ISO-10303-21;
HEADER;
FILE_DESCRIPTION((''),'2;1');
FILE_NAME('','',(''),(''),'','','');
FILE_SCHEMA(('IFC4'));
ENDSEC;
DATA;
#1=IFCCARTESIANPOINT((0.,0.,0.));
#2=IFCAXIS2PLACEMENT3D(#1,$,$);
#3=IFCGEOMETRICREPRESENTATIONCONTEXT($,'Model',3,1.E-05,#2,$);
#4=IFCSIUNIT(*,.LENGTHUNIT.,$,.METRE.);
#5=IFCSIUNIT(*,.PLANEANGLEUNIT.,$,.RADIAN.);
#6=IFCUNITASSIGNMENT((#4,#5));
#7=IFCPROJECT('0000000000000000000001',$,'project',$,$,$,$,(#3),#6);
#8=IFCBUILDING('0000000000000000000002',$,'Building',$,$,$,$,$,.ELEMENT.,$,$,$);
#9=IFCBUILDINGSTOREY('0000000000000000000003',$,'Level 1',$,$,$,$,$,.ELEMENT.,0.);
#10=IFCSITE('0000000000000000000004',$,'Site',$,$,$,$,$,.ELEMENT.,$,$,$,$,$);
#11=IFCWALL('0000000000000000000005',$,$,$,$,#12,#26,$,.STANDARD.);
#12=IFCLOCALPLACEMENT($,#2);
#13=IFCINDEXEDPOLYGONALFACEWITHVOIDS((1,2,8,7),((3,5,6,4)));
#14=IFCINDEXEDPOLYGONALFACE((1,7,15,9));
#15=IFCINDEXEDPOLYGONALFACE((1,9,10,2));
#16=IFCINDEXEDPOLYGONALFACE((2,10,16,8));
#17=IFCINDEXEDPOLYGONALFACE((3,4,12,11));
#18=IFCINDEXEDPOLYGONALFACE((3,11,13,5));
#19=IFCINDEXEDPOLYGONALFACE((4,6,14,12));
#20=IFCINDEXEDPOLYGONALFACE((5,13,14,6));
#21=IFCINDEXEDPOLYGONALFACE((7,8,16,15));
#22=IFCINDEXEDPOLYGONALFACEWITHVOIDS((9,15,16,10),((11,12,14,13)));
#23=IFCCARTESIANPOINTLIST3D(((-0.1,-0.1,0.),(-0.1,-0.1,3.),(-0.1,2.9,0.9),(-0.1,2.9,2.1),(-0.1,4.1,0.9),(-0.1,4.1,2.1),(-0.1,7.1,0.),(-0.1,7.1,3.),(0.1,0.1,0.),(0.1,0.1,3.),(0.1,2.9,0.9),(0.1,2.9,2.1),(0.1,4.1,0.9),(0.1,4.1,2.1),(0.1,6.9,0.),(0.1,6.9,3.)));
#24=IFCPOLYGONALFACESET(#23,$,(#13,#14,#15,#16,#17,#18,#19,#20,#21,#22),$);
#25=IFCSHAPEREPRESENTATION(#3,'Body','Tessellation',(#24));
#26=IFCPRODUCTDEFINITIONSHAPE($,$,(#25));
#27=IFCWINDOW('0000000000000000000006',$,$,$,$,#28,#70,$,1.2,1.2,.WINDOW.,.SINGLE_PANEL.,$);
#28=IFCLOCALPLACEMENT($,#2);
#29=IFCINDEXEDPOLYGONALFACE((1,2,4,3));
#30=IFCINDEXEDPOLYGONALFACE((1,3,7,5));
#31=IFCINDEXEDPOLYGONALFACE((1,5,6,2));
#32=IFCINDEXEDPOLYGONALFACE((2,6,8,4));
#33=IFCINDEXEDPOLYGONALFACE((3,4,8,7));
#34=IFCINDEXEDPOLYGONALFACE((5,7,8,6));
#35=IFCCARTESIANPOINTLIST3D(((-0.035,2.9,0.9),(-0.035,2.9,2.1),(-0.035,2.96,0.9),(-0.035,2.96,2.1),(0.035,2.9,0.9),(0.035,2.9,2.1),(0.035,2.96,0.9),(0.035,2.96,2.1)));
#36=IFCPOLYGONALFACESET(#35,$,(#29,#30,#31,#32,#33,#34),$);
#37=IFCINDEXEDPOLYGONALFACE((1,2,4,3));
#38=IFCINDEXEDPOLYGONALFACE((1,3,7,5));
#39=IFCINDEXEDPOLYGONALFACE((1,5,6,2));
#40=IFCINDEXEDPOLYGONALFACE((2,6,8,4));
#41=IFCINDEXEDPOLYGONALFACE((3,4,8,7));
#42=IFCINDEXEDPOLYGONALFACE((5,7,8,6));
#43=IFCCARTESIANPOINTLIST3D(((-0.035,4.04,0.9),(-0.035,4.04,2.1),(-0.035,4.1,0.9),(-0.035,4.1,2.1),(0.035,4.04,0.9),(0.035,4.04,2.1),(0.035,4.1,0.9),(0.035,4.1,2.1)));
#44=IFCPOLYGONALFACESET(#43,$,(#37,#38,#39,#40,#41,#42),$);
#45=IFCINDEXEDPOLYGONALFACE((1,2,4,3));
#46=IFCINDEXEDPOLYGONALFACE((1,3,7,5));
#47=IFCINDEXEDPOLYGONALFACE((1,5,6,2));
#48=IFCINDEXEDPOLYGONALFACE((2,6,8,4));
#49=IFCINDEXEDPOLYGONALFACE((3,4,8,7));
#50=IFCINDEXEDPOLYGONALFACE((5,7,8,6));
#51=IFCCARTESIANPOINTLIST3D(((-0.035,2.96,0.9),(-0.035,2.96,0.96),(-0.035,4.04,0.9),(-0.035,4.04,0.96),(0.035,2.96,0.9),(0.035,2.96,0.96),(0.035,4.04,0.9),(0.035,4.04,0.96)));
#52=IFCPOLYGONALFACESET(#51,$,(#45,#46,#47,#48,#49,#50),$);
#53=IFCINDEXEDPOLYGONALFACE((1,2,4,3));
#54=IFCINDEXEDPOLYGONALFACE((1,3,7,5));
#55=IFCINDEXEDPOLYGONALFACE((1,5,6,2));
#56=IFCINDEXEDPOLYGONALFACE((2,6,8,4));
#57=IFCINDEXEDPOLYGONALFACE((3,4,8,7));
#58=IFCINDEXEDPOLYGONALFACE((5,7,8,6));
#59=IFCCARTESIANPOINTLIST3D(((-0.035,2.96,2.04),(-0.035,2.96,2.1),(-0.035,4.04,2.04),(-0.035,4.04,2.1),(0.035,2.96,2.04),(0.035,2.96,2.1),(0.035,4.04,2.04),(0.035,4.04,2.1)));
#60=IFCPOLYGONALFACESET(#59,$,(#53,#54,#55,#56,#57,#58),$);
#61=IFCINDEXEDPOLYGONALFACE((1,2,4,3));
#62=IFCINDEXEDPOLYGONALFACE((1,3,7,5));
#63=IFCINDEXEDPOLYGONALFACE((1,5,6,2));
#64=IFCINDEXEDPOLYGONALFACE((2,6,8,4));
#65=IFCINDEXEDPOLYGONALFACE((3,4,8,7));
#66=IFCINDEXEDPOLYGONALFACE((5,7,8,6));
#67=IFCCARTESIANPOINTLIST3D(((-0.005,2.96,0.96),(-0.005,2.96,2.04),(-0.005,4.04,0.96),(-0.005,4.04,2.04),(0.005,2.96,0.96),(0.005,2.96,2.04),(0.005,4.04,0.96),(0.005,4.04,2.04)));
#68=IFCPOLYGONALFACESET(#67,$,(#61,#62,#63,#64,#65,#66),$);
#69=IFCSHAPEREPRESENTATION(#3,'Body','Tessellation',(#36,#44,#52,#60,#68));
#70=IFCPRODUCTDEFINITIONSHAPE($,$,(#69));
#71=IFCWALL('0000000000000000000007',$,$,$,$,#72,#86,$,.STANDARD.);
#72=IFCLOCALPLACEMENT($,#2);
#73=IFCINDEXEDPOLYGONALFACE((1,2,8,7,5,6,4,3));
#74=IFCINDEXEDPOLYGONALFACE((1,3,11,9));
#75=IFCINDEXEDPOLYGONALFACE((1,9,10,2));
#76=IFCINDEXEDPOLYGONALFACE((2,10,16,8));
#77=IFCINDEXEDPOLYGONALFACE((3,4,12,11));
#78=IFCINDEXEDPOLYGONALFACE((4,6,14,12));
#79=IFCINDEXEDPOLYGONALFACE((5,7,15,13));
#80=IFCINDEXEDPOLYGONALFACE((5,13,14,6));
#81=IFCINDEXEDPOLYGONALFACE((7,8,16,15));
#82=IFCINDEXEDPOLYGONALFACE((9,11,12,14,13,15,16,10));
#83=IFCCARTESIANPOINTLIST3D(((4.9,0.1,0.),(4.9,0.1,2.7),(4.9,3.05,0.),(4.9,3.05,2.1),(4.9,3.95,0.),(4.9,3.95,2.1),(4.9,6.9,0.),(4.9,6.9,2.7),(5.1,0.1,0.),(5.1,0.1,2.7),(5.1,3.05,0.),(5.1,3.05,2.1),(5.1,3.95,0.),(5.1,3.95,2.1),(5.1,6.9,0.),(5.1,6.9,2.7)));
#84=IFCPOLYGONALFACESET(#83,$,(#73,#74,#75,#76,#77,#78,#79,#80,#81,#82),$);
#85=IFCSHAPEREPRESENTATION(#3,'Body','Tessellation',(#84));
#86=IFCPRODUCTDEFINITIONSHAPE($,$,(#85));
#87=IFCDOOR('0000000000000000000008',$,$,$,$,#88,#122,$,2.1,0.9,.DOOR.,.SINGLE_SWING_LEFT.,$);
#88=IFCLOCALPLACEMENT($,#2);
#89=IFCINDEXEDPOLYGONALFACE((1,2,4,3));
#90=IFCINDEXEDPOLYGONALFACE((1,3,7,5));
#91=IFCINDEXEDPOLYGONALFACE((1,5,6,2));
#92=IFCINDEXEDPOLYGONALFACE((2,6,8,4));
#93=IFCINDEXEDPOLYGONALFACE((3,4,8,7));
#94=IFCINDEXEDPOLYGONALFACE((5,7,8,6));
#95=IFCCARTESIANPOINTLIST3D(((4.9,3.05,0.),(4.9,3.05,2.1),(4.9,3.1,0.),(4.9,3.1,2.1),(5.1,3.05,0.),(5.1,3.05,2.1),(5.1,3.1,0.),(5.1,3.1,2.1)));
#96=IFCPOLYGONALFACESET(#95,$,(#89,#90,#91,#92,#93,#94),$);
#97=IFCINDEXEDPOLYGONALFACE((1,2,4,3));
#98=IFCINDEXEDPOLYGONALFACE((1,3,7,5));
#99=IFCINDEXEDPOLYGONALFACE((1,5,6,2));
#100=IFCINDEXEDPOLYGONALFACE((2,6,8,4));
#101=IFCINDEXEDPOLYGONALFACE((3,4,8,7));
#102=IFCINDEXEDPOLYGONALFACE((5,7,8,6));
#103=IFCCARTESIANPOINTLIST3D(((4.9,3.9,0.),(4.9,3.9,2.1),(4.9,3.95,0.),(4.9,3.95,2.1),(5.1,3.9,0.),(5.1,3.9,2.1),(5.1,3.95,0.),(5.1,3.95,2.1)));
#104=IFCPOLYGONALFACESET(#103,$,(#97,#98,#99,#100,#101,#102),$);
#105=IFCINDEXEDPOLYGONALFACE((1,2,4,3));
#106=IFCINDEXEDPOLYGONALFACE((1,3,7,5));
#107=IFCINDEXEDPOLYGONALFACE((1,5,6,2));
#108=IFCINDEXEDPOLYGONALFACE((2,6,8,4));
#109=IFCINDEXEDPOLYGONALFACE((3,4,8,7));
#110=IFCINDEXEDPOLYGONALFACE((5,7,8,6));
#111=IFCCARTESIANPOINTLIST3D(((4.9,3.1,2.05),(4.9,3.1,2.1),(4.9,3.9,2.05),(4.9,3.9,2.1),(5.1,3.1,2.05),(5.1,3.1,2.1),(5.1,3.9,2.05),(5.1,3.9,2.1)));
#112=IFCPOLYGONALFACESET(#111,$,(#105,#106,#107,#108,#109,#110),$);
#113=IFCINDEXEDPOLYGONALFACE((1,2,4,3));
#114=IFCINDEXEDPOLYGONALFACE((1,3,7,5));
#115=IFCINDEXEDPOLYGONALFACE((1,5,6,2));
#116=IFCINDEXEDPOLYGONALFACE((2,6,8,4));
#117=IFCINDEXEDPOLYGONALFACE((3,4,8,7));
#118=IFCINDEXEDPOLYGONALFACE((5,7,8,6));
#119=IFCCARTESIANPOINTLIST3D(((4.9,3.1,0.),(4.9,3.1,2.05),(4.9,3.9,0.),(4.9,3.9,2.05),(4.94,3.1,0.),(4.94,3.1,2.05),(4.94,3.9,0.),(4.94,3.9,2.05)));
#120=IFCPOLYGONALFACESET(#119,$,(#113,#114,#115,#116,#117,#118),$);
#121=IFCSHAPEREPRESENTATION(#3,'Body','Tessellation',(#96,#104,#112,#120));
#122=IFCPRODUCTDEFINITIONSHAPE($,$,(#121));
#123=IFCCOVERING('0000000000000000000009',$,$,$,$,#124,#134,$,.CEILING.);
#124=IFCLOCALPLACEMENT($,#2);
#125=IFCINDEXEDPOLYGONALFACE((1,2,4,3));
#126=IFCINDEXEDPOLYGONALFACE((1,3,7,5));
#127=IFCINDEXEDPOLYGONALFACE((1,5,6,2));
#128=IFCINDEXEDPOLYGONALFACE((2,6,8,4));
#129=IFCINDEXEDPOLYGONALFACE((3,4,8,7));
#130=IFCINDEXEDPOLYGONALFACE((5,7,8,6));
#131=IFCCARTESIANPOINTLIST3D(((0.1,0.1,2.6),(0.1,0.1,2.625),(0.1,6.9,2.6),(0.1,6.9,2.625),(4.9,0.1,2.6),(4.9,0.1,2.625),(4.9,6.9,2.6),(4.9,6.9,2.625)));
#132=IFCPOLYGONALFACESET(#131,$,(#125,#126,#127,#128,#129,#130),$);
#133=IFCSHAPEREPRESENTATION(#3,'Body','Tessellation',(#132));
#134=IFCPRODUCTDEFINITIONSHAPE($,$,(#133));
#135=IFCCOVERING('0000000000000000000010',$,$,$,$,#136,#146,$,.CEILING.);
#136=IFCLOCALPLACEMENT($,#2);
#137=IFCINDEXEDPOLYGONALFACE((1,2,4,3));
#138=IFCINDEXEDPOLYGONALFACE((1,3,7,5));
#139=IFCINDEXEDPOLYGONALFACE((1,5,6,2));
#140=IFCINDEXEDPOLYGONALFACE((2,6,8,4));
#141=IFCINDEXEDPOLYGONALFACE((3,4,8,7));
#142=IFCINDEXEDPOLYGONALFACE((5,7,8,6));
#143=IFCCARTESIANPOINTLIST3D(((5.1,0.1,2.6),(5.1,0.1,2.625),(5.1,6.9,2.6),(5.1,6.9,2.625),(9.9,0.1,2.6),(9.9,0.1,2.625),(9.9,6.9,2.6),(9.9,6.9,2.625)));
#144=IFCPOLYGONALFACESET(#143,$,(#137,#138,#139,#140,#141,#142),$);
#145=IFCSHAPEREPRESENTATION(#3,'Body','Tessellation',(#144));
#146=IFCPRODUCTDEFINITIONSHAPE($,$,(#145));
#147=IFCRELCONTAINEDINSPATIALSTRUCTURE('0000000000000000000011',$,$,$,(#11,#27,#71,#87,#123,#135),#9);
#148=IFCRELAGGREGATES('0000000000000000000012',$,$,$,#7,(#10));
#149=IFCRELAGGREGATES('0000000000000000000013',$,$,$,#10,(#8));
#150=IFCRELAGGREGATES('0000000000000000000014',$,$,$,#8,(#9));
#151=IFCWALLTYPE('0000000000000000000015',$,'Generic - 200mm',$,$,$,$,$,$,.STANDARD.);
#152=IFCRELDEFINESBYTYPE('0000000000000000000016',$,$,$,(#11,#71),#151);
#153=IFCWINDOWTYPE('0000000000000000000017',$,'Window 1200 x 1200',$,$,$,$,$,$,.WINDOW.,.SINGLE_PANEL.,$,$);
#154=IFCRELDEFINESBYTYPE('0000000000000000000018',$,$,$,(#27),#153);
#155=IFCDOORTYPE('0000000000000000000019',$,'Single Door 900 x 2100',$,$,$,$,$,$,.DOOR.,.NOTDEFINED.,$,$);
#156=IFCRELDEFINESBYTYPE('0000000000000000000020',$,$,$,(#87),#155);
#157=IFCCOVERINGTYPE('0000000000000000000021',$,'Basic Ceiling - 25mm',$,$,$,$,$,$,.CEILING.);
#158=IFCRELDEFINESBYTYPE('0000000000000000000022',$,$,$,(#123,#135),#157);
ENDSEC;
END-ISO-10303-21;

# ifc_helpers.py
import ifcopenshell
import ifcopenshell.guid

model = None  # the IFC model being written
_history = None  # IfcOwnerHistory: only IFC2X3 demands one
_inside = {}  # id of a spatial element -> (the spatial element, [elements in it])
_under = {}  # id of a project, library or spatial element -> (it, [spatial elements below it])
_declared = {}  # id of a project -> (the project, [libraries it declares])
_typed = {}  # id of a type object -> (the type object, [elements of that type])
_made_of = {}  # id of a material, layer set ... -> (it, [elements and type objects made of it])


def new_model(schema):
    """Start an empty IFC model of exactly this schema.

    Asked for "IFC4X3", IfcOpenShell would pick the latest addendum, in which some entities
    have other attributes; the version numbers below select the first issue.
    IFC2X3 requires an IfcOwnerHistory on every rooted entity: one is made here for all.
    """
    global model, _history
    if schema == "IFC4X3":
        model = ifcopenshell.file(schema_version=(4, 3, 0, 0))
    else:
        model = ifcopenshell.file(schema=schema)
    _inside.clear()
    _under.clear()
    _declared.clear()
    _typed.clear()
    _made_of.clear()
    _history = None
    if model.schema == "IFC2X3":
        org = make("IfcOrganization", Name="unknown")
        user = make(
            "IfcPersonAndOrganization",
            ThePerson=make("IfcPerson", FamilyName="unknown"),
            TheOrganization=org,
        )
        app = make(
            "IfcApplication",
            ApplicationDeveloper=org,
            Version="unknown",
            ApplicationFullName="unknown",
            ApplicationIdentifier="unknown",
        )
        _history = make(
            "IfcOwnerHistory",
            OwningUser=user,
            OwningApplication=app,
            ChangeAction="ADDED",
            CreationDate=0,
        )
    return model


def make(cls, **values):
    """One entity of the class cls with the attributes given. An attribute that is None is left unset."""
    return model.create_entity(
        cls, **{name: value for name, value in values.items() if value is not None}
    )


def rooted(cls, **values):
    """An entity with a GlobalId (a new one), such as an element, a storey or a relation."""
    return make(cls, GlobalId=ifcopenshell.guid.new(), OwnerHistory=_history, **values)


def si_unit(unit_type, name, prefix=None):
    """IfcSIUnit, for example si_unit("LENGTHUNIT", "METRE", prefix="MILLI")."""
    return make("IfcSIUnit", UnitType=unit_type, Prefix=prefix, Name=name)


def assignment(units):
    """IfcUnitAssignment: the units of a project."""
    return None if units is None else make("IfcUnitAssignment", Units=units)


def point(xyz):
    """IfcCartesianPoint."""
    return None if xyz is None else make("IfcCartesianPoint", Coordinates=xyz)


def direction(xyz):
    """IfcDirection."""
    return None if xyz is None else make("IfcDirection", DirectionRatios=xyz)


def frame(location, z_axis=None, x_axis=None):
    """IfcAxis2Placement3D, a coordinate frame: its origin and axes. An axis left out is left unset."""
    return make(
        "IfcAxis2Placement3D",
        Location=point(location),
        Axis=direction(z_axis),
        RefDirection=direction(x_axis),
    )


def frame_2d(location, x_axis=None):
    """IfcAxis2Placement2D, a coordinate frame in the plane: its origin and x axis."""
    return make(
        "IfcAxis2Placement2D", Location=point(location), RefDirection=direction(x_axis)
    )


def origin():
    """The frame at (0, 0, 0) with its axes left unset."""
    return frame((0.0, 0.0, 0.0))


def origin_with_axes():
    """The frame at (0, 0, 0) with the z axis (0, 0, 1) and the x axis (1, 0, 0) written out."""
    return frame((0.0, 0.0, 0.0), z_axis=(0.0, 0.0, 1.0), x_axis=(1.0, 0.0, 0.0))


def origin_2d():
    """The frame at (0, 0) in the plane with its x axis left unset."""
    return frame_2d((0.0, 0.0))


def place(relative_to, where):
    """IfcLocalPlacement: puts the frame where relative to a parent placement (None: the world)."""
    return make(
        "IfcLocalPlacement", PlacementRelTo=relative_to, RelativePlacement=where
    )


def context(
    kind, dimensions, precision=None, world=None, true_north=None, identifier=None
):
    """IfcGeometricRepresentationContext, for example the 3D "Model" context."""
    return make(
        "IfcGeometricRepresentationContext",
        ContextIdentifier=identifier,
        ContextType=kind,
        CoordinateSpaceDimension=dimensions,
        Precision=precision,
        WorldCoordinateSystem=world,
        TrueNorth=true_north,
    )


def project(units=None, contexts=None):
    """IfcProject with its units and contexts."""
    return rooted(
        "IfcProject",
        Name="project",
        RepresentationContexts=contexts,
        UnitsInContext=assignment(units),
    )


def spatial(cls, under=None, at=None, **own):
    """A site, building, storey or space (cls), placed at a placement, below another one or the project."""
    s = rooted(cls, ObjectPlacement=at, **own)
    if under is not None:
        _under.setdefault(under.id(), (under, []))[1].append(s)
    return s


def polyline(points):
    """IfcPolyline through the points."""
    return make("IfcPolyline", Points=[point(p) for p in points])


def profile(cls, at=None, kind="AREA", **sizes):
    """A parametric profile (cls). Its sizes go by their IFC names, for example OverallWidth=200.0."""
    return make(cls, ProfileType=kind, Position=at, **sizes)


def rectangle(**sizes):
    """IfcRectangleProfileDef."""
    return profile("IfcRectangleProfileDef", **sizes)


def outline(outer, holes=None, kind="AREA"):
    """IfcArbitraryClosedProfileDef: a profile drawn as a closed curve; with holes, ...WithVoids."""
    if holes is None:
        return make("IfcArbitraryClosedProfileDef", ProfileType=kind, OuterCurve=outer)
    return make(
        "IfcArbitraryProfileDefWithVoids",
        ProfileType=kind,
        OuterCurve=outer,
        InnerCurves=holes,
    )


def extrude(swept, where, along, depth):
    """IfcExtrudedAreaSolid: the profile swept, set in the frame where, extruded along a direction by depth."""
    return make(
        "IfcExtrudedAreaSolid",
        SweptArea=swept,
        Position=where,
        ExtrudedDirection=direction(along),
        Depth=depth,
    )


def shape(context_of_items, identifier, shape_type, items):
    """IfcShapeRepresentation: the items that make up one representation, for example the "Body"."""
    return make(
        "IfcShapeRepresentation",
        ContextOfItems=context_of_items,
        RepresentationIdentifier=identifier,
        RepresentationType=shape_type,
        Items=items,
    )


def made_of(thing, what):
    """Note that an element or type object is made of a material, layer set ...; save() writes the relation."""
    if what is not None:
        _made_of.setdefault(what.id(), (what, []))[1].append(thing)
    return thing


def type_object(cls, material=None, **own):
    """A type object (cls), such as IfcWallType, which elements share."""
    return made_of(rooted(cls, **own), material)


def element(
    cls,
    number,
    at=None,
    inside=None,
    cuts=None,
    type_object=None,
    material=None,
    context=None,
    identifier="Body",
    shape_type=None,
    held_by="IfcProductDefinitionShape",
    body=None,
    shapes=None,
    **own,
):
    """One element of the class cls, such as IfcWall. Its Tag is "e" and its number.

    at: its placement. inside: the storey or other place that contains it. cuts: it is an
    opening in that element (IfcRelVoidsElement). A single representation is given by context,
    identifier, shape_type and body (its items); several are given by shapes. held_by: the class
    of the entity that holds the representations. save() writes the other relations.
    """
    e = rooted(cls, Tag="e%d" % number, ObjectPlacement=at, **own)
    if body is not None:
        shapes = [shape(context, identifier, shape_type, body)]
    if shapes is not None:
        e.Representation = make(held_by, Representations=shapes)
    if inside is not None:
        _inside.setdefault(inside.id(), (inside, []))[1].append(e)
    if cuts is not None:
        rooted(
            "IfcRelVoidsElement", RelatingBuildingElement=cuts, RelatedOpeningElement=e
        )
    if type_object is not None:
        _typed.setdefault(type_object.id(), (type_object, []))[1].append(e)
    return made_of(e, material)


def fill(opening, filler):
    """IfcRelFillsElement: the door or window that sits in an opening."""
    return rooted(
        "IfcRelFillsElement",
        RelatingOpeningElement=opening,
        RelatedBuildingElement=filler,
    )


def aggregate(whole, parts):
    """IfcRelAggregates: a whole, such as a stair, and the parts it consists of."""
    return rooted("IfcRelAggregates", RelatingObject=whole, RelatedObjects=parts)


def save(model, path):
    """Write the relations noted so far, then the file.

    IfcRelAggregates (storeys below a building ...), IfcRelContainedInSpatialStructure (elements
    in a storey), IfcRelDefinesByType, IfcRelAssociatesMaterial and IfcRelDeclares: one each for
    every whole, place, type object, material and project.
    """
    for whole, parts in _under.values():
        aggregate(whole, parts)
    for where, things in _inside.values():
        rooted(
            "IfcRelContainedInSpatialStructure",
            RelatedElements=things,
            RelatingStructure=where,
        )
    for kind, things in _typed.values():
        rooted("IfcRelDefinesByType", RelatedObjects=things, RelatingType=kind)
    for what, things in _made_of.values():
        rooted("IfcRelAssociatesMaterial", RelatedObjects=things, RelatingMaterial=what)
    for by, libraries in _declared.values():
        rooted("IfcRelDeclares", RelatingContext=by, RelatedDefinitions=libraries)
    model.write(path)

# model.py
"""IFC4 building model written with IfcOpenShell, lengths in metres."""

from ifc_helpers import new_model, si_unit, frame, frame_2d, origin, origin_with_axes, origin_2d, place, context, project, spatial, polyline, rectangle, outline, extrude, type_object, element, fill, save


model = new_model("IFC4")

# Units and contexts
model_context = context("Model", 3, precision=1e-05, world=origin())
ifc_project = project(units=[si_unit("LENGTHUNIT", "METRE"), si_unit("PLANEANGLEUNIT", "RADIAN")], contexts=[model_context])

# Site, building, storey
site = spatial("IfcSite", under=ifc_project, Name="Site", CompositionType="ELEMENT")
building = spatial("IfcBuilding", under=site, Name="Building", CompositionType="ELEMENT")
storey = spatial("IfcBuildingStorey", under=building, Name="Level 1", CompositionType="ELEMENT", Elevation=0.0)

# Shared definitions
wall_type = type_object("IfcWallType", Name="Generic - 200mm", PredefinedType="STANDARD")
door_type = type_object("IfcDoorType", Name="Single Door 900 x 2100", OperationType="NOTDEFINED", PredefinedType="DOOR")
window_type = type_object("IfcWindowType", Name="Window 1200 x 1200", PartitioningType="SINGLE_PANEL", PredefinedType="WINDOW")

# Wall, opening, window
wall_1_placement = place(None, frame((0.0, 0.0, 0.0), z_axis=(0.0, 0.0, 1.0), x_axis=(0.0, 1.0, 0.0)))
wall_1 = element("IfcWall", 1, at=wall_1_placement, inside=storey, type_object=wall_type, PredefinedType="STANDARD", context=model_context, shape_type="SweptSolid", body=[
    extrude(outline(polyline([(0.1, -0.1), (6.9, -0.1), (7.1, 0.1), (-0.1, 0.1), (0.1, -0.1)])), origin(), (0.0, 0.0, 1.0), 3.0),
])
opening_1_placement = place(wall_1_placement, frame((3.5, 0.0, 0.9), z_axis=(0.0, 0.0, 1.0), x_axis=(1.0, 0.0, 0.0)))
opening_1 = element("IfcOpeningElement", 2, at=opening_1_placement, cuts=wall_1, PredefinedType="OPENING", context=model_context, shape_type="SweptSolid", body=[
    extrude(rectangle(XDim=1.2, YDim=0.202, at=origin_2d()), origin(), (0.0, 0.0, 1.0), 1.2),
])
window_1_placement = place(opening_1_placement, origin_with_axes())
window_1 = element("IfcWindow", 3, at=window_1_placement, inside=storey, type_object=window_type, OverallHeight=1.2, OverallWidth=1.2, PartitioningType="SINGLE_PANEL", PredefinedType="WINDOW", context=model_context, shape_type="SweptSolid", body=[
    extrude(rectangle(XDim=0.06, YDim=0.07, at=frame_2d((-0.57, 0.0))), origin(), (0.0, 0.0, 1.0), 1.2),
    extrude(rectangle(XDim=0.06, YDim=0.07, at=frame_2d((0.57, 0.0))), origin(), (0.0, 0.0, 1.0), 1.2),
    extrude(rectangle(XDim=1.08, YDim=0.07, at=origin_2d()), origin(), (0.0, 0.0, 1.0), 0.06),
    extrude(rectangle(XDim=1.08, YDim=0.07, at=origin_2d()), frame((0.0, 0.0, 1.14)), (0.0, 0.0, 1.0), 0.06),
    extrude(rectangle(XDim=1.08, YDim=0.01, at=origin_2d()), frame((0.0, 0.0, 0.06)), (0.0, 0.0, 1.0), 1.08),
])
fill(opening_1, window_1)

# Wall, opening, door
wall_2_placement = place(None, frame((5.0, 0.0, 0.0), z_axis=(0.0, 0.0, 1.0), x_axis=(0.0, 1.0, 0.0)))
wall_2 = element("IfcWall", 4, at=wall_2_placement, inside=storey, type_object=wall_type, PredefinedType="STANDARD", context=model_context, shape_type="SweptSolid", body=[
    extrude(outline(polyline([(0.1, -0.1), (6.9, -0.1), (6.9, 0.1), (0.1, 0.1), (0.1, -0.1)])), origin(), (0.0, 0.0, 1.0), 2.7),
])
opening_2_placement = place(wall_2_placement, frame((3.5, 0.0, 0.0), z_axis=(0.0, 0.0, 1.0), x_axis=(1.0, 0.0, 0.0)))
opening_2 = element("IfcOpeningElement", 5, at=opening_2_placement, cuts=wall_2, PredefinedType="OPENING", context=model_context, shape_type="SweptSolid", body=[
    extrude(rectangle(XDim=0.9, YDim=0.202, at=origin_2d()), origin(), (0.0, 0.0, 1.0), 2.1),
])
door_1_placement = place(opening_2_placement, origin_with_axes())
door_1 = element("IfcDoor", 6, at=door_1_placement, inside=storey, type_object=door_type, OperationType="SINGLE_SWING_LEFT", OverallHeight=2.1, OverallWidth=0.9, PredefinedType="DOOR", context=model_context, shape_type="SweptSolid", body=[
    extrude(rectangle(XDim=0.05, YDim=0.2, at=frame_2d((-0.425, 0.0))), origin(), (0.0, 0.0, 1.0), 2.1),
    extrude(rectangle(XDim=0.05, YDim=0.2, at=frame_2d((0.425, 0.0))), origin(), (0.0, 0.0, 1.0), 2.1),
    extrude(rectangle(XDim=0.8, YDim=0.2, at=origin_2d()), frame((0.0, 0.0, 2.05)), (0.0, 0.0, 1.0), 0.05),
    extrude(rectangle(XDim=0.8, YDim=0.04, at=frame_2d((0.0, 0.08))), origin(), (0.0, 0.0, 1.0), 2.05),
])
fill(opening_2, door_1)

# Coverings
covering_type = type_object("IfcCoveringType", Name="Basic Ceiling - 25mm", PredefinedType="CEILING")
covering_1_placement = place(None, frame((0.0, 0.0, 2.625)))
element("IfcCovering", 7, at=covering_1_placement, inside=storey, type_object=covering_type, PredefinedType="CEILING", context=model_context, shape_type="SweptSolid", body=[
    extrude(outline(polyline([(0.1, 0.1), (4.9, 0.1), (4.9, 6.9), (0.1, 6.9), (0.1, 0.1)])), origin(), (0.0, 0.0, -1.0), 0.025),
])
covering_2_placement = place(None, frame((0.0, 0.0, 2.625)))
element("IfcCovering", 8, at=covering_2_placement, inside=storey, type_object=covering_type, PredefinedType="CEILING", context=model_context, shape_type="SweptSolid", body=[
    extrude(outline(polyline([(5.1, 0.1), (9.9, 0.1), (9.9, 6.9), (5.1, 6.9), (5.1, 0.1)])), origin(), (0.0, 0.0, -1.0), 0.025),
])

save(model, "model.ifc")
